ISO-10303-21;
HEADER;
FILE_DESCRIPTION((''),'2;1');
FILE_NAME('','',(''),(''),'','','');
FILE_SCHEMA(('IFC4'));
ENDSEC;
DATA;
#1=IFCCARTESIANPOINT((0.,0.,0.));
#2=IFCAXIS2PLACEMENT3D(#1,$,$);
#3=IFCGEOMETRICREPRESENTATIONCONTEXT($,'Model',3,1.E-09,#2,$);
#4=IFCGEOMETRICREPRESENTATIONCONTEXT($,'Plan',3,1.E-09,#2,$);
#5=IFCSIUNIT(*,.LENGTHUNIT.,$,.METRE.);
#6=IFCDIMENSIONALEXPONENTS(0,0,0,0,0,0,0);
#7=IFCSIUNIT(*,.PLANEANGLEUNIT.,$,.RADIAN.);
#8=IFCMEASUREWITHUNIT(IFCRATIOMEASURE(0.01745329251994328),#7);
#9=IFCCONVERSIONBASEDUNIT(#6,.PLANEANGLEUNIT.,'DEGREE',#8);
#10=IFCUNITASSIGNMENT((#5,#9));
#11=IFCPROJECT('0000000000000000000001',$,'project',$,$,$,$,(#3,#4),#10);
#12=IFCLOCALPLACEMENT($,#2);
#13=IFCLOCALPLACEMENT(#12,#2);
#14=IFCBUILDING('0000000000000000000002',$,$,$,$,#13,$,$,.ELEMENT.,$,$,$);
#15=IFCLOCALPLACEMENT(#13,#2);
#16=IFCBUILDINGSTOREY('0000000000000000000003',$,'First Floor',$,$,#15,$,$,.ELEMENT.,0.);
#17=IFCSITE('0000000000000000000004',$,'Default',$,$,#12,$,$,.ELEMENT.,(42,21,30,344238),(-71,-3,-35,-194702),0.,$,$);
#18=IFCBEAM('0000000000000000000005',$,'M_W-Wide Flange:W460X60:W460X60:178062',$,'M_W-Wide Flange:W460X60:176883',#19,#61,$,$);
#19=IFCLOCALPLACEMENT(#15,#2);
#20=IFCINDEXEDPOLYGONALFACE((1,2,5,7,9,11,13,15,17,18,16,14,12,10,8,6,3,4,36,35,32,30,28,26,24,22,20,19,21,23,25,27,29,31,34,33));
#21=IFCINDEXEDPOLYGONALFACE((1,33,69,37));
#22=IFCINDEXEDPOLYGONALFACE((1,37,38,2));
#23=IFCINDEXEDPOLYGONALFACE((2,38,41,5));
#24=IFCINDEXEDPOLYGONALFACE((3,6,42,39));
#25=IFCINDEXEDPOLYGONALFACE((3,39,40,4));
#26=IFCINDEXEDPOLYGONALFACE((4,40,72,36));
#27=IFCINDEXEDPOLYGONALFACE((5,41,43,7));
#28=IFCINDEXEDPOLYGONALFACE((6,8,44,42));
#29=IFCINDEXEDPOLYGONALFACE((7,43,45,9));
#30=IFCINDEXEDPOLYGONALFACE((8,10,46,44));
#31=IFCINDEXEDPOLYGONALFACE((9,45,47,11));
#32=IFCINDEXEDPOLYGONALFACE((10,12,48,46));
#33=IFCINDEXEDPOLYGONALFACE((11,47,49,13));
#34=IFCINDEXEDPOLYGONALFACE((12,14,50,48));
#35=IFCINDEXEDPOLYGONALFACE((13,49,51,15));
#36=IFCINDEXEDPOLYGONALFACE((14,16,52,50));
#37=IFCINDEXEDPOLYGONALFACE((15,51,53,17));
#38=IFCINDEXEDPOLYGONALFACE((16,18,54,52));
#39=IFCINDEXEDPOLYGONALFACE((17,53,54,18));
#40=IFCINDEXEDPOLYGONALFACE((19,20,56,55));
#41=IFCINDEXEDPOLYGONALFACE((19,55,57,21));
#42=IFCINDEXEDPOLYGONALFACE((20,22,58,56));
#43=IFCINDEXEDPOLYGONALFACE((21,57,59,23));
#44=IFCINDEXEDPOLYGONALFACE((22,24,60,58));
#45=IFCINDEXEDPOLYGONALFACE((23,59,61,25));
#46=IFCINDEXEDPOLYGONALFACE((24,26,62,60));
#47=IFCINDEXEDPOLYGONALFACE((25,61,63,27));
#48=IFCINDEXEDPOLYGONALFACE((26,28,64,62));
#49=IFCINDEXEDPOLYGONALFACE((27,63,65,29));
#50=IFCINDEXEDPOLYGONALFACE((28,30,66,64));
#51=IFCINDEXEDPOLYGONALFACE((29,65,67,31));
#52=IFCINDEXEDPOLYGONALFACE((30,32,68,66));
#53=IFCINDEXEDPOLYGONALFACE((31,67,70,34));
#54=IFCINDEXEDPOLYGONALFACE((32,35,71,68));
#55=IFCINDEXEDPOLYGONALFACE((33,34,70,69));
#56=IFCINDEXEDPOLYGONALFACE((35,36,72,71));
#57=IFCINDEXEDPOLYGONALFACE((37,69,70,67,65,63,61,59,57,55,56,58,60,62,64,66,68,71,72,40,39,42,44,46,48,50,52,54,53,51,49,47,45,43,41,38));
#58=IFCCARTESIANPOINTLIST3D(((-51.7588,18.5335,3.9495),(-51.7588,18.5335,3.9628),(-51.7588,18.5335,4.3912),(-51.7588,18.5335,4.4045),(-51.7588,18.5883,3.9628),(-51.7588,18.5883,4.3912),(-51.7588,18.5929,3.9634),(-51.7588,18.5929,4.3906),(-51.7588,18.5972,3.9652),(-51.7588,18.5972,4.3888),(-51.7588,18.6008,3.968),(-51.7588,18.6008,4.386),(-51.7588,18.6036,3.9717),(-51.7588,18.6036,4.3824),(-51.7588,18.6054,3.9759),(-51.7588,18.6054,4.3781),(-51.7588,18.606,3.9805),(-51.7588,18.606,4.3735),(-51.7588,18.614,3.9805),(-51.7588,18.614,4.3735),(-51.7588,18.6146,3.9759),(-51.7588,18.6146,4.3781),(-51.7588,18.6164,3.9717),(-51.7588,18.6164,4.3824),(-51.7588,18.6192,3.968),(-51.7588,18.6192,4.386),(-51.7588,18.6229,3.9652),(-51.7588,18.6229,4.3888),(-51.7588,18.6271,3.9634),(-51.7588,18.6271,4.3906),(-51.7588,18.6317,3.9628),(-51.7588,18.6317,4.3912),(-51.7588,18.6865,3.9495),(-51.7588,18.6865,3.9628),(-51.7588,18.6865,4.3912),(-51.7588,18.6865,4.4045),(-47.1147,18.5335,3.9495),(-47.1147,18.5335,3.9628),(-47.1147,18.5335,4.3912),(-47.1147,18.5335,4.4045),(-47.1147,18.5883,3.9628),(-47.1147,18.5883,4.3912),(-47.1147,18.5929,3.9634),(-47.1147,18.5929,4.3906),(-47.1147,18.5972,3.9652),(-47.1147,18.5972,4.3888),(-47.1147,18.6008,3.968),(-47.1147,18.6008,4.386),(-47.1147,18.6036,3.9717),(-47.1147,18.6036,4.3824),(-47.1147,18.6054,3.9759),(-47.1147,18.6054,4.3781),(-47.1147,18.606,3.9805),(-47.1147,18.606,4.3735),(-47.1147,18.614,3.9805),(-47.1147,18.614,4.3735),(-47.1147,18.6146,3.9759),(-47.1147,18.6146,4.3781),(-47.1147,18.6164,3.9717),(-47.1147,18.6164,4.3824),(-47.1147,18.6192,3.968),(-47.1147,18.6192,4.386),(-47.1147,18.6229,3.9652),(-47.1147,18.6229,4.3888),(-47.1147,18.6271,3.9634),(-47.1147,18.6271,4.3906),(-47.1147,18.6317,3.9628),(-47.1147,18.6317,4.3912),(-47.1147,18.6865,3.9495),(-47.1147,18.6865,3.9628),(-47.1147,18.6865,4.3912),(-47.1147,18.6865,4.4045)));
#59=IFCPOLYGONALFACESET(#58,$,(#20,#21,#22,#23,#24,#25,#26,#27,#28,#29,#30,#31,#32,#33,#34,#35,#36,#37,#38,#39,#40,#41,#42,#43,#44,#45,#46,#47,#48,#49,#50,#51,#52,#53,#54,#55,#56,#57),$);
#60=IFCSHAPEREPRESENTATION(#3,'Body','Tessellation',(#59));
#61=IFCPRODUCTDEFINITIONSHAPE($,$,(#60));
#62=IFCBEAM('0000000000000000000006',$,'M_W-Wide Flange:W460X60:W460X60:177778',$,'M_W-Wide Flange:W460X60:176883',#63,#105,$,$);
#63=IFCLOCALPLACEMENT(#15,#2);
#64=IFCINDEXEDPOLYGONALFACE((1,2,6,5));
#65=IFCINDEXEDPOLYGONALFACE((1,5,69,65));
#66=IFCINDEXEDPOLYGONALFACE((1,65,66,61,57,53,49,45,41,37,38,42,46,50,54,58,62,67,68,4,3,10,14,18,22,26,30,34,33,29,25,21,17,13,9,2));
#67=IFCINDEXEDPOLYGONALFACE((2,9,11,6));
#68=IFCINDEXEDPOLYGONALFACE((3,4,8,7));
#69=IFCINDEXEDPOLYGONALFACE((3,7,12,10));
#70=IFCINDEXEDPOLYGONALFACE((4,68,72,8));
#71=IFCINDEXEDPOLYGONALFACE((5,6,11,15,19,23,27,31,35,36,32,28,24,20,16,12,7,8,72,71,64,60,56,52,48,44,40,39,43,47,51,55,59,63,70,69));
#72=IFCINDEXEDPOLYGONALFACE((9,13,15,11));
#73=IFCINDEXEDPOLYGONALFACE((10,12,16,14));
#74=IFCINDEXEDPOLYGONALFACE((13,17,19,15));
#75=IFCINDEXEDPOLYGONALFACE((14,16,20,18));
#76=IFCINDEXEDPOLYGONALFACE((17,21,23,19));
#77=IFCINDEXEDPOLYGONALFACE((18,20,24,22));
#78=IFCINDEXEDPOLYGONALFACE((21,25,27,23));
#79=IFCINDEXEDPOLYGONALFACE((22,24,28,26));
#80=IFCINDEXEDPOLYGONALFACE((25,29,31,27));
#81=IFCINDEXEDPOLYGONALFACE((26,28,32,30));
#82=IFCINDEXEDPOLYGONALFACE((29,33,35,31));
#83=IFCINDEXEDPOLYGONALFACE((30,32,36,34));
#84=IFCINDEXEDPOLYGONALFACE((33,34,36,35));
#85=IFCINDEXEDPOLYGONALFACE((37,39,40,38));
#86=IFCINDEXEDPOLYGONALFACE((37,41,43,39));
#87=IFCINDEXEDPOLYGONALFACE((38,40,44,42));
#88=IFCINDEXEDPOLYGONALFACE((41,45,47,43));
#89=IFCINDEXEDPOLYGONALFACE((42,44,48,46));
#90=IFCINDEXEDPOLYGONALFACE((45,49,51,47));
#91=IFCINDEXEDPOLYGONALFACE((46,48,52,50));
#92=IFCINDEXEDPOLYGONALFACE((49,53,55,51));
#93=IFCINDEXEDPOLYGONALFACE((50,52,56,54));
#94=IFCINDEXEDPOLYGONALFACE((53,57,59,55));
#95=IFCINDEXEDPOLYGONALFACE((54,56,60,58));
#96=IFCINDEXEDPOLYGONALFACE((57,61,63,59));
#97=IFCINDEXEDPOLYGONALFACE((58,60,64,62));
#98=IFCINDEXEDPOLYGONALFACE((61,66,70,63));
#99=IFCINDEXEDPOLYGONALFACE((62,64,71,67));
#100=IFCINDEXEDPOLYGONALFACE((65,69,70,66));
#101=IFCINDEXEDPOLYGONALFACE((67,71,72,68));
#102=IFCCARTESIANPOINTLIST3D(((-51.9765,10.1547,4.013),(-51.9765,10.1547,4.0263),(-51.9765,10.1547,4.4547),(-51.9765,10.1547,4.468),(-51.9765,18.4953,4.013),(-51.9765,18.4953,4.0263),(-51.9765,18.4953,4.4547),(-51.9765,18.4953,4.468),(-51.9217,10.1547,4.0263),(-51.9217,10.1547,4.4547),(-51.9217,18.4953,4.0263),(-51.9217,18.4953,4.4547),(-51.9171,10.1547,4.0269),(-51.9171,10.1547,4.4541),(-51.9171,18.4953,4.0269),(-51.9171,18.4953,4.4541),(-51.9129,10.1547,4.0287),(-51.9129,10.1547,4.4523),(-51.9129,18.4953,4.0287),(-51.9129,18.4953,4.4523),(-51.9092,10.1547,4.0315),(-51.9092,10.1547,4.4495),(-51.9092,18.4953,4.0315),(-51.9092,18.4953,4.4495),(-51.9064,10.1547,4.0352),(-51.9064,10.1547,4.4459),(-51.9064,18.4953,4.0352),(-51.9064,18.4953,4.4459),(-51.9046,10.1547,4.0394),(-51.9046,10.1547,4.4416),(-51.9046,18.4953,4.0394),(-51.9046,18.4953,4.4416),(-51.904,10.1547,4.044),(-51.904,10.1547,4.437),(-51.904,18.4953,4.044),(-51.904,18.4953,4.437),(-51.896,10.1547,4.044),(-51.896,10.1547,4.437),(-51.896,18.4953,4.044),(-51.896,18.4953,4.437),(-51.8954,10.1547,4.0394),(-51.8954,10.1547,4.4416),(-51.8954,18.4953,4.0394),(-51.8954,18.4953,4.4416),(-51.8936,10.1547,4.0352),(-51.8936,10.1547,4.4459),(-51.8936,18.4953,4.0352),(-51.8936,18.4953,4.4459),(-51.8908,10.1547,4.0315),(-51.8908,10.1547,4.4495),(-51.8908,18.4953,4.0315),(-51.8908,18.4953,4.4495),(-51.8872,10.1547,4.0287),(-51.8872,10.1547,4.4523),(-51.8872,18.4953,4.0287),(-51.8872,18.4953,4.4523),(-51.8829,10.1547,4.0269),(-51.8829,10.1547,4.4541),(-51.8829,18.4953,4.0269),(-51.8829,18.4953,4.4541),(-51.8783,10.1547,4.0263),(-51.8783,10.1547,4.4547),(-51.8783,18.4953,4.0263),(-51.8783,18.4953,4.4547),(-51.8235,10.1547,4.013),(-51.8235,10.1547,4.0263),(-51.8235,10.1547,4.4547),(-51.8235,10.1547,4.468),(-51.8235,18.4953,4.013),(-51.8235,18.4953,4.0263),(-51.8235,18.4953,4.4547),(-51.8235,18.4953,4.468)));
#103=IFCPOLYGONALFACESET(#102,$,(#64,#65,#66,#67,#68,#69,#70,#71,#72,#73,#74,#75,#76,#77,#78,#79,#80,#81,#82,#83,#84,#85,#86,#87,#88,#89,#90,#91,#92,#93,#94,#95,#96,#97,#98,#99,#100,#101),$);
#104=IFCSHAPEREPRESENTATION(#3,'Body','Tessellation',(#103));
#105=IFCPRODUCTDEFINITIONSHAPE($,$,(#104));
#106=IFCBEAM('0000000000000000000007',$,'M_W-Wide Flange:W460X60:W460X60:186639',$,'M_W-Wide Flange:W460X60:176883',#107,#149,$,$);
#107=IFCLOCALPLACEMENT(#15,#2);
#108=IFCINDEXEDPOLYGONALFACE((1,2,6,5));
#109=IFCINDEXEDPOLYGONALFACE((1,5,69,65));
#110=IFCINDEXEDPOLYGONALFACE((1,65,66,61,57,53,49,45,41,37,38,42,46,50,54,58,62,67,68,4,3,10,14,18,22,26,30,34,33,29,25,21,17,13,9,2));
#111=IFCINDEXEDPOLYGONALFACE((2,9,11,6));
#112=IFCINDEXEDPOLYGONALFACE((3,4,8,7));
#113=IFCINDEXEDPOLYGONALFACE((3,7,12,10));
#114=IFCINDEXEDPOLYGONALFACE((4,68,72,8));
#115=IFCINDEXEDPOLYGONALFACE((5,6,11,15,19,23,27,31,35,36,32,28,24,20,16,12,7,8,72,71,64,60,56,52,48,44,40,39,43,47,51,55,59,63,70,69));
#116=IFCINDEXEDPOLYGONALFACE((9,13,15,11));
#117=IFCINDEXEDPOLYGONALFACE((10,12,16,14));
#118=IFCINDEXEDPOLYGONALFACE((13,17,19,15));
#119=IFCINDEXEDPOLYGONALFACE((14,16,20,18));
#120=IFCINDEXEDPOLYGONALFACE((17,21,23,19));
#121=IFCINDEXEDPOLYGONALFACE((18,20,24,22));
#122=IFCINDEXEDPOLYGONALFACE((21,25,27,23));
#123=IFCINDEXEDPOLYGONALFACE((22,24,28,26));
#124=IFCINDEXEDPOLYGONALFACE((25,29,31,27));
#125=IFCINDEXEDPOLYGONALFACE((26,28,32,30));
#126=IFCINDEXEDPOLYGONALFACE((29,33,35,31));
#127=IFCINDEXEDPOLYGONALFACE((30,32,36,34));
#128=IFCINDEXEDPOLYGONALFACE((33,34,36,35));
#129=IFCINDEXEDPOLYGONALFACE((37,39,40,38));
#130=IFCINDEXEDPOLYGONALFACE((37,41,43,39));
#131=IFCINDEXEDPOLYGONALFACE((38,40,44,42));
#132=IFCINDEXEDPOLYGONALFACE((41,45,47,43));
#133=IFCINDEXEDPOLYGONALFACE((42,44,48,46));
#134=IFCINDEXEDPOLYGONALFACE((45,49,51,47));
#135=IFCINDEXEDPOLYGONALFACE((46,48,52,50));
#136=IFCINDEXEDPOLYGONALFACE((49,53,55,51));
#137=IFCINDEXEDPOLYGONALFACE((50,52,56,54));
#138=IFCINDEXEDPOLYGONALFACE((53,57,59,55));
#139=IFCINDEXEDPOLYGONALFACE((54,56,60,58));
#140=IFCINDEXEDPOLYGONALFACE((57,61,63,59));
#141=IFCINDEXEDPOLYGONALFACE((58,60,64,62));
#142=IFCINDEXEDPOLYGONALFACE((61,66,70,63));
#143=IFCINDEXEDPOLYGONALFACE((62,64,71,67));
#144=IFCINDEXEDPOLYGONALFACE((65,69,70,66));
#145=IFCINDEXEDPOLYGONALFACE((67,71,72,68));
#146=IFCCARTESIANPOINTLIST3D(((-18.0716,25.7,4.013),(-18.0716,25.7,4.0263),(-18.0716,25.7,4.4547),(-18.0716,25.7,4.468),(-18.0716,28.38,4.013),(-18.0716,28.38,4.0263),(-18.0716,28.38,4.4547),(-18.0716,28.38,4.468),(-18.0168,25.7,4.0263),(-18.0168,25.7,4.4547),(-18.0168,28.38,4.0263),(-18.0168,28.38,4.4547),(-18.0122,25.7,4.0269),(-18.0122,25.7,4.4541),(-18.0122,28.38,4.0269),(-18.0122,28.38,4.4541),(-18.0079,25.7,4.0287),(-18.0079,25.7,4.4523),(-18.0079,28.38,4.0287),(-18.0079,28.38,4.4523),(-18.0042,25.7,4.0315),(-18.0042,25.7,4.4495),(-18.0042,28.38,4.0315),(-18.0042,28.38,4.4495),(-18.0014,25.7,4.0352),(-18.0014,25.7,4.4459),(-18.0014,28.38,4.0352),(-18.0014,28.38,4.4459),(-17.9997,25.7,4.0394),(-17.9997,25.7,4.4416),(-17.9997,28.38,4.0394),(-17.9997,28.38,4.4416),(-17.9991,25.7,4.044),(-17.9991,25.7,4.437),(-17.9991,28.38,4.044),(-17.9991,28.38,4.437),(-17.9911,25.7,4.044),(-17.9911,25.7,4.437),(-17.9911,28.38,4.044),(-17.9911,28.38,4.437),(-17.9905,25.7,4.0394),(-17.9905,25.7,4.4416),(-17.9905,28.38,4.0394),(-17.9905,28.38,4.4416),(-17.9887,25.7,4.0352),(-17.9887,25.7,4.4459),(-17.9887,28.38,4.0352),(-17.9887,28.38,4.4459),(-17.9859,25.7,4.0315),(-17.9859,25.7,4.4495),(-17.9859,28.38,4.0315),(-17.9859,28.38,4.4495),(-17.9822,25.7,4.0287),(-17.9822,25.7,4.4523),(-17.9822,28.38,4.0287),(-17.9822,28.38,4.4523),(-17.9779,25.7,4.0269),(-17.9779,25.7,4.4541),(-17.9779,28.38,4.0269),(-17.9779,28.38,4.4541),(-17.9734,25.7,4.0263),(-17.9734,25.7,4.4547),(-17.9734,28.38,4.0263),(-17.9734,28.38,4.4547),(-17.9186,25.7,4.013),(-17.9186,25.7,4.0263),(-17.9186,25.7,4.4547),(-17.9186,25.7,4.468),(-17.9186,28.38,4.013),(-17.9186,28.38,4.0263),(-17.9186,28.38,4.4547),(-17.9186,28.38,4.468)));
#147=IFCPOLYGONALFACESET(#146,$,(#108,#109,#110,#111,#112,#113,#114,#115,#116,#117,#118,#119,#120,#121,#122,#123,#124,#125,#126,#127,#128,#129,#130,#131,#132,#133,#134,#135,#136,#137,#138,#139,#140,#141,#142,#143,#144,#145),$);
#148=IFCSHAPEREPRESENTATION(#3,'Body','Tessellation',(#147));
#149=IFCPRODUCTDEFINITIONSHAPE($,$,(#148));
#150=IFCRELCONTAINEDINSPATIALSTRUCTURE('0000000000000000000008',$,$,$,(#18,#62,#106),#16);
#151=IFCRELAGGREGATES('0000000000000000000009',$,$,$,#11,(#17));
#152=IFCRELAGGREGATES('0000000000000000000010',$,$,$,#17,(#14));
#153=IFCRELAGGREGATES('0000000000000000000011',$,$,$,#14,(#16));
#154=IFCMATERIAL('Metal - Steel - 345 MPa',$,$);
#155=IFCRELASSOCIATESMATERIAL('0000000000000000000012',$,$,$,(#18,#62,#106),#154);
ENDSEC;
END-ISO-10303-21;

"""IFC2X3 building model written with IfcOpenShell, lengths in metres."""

from ifc_helpers import new_model, entity, si_unit, converted_unit, frame, frame_2d, origin, place, context, project, spatial, polyline, circle_curve, parameter, trimmed, segment, composite_curve, outline, extrude, material, element, save


model = new_model("IFC2X3")

# Units and contexts
model_context = context("Model", 3, precision=1e-09, world=origin())
plan_context = context("Plan", 3, precision=1e-09, world=origin())
ifc_project = project(units=[si_unit("LENGTHUNIT", "METRE"), converted_unit("PLANEANGLEUNIT", "DEGREE", entity("IfcRatioMeasure", 0.01745329251994328), si_unit("PLANEANGLEUNIT", "RADIAN"), dimensions=[0, 0, 0, 0, 0, 0, 0])], contexts=[model_context, plan_context])

# Site, building, storey
site_placement = place(None, origin())
site = spatial("IfcSite", under=ifc_project, at=site_placement, Name="Default", CompositionType="ELEMENT", RefLatitude=(42, 21, 30, 344238), RefLongitude=(-71, -3, -35, -194702), RefElevation=0.0)
building_placement = place(site_placement, origin())
building = spatial("IfcBuilding", under=site, at=building_placement, CompositionType="ELEMENT")
storey_placement = place(building_placement, origin())
storey = spatial("IfcBuildingStorey", under=building, at=storey_placement, Name="First Floor", CompositionType="ELEMENT", Elevation=0.0)

# Beams
ifc_material_1 = material(Name="Metal - Steel - 345 MPa")
beam_1_placement = place(storey_placement, frame((-51.9028, 18.61, 4.4045), z_axis=(0.0, 0.0, 1.0), x_axis=(0.0, -1.0, 0.0)))
element("IfcBeam", 1, at=beam_1_placement, inside=storey, material=ifc_material_1, Name="M_W-Wide Flange:W460X60:W460X60:178062", ObjectType="M_W-Wide Flange:W460X60:176883", context=model_context, shape_type="SweptSolid", body=[
    extrude(outline(composite_curve([segment(polyline([(-0.0765, -0.2142), (-0.0765, -0.2275)]), True, "CONTINUOUS"), segment(polyline([(-0.0765, -0.2275), (0.0765, -0.2275)]), True, "CONTINUOUS"), segment(polyline([(0.0765, -0.2275), (0.0765, -0.2142)]), True, "CONTINUOUS"), segment(polyline([(0.0765, -0.2142), (0.0217, -0.2142)]), True, "CONTINUOUS"), segment(trimmed(circle_curve(frame_2d((0.0217, -0.1965), x_axis=(1.0, 0.0)), 0.0177), [parameter(180.0)], [parameter(270.0)], True, "PARAMETER"), False, "CONTINUOUS"), segment(polyline([(0.004, -0.1965), (0.004, 0.1965)]), True, "CONTINUOUS"), segment(trimmed(circle_curve(frame_2d((0.0217, 0.1965), x_axis=(1.0, 0.0)), 0.0177), [parameter(90.0)], [parameter(180.0)], True, "PARAMETER"), False, "CONTINUOUS"), segment(polyline([(0.0217, 0.2142), (0.0765, 0.2142)]), True, "CONTINUOUS"), segment(polyline([(0.0765, 0.2142), (0.0765, 0.2275)]), True, "CONTINUOUS"), segment(polyline([(0.0765, 0.2275), (-0.0765, 0.2275)]), True, "CONTINUOUS"), segment(polyline([(-0.0765, 0.2275), (-0.0765, 0.2142)]), True, "CONTINUOUS"), segment(polyline([(-0.0765, 0.2142), (-0.0217, 0.2142)]), True, "CONTINUOUS"), segment(trimmed(circle_curve(frame_2d((-0.0217, 0.1965), x_axis=(1.0, 0.0)), 0.0177), [parameter(360.0)], [parameter(90.0)], True, "PARAMETER"), False, "CONTINUOUS"), segment(polyline([(-0.004, 0.1965), (-0.004, -0.1965)]), True, "CONTINUOUS"), segment(trimmed(circle_curve(frame_2d((-0.0217, -0.1965), x_axis=(1.0, 0.0)), 0.0177), [parameter(270.0)], [parameter(0.0)], True, "PARAMETER"), False, "CONTINUOUS"), segment(polyline([(-0.0217, -0.2142), (-0.0765, -0.2142)]), True, "CONTINUOUS")], self_intersect=False)), frame((0.0, 0.144, -0.2275), z_axis=(0.0, -1.0, 0.0), x_axis=(1.0, 0.0, 0.0)), (0.0, 0.0, -1.0), 4.6441),
])
beam_2_placement = place(storey_placement, frame((-51.9, 18.6116, 4.468), z_axis=(0.0, 0.0, 1.0), x_axis=(-1.0, 0.0, 0.0)))
element("IfcBeam", 2, at=beam_2_placement, inside=storey, material=ifc_material_1, Name="M_W-Wide Flange:W460X60:W460X60:177778", ObjectType="M_W-Wide Flange:W460X60:176883", context=model_context, shape_type="SweptSolid", body=[
    extrude(outline(composite_curve([segment(polyline([(0.2142, -0.0765), (0.2275, -0.0765)]), True, "CONTINUOUS"), segment(polyline([(0.2275, -0.0765), (0.2275, 0.0765)]), True, "CONTINUOUS"), segment(polyline([(0.2275, 0.0765), (0.2142, 0.0765)]), True, "CONTINUOUS"), segment(polyline([(0.2142, 0.0765), (0.2142, 0.0217)]), True, "CONTINUOUS"), segment(trimmed(circle_curve(frame_2d((0.1965, 0.0217), x_axis=(1.0, 0.0)), 0.0177), [parameter(270.0)], [parameter(360.0)], True, "PARAMETER"), False, "CONTINUOUS"), segment(polyline([(0.1965, 0.004), (-0.1965, 0.004)]), True, "CONTINUOUS"), segment(trimmed(circle_curve(frame_2d((-0.1965, 0.0217), x_axis=(0.0, -1.0)), 0.0177), [parameter(270.0)], [parameter(360.0)], True, "PARAMETER"), False, "CONTINUOUS"), segment(polyline([(-0.2142, 0.0217), (-0.2142, 0.0765)]), True, "CONTINUOUS"), segment(polyline([(-0.2142, 0.0765), (-0.2275, 0.0765)]), True, "CONTINUOUS"), segment(polyline([(-0.2275, 0.0765), (-0.2275, -0.0765)]), True, "CONTINUOUS"), segment(polyline([(-0.2275, -0.0765), (-0.2142, -0.0765)]), True, "CONTINUOUS"), segment(polyline([(-0.2142, -0.0765), (-0.2142, -0.0217)]), True, "CONTINUOUS"), segment(trimmed(circle_curve(frame_2d((-0.1965, -0.0217), x_axis=(-1.0, 0.0)), 0.0177), [parameter(270.0)], [parameter(360.0)], True, "PARAMETER"), False, "CONTINUOUS"), segment(polyline([(-0.1965, -0.004), (0.1965, -0.004)]), True, "CONTINUOUS"), segment(trimmed(circle_curve(frame_2d((0.1965, -0.0217), x_axis=(0.0, 1.0)), 0.0177), [parameter(270.0)], [parameter(0.0)], True, "PARAMETER"), False, "CONTINUOUS"), segment(polyline([(0.2142, -0.0217), (0.2142, -0.0765)]), True, "CONTINUOUS")], self_intersect=False)), frame((0.0, 8.4569, -0.2275), z_axis=(0.0, -1.0, 0.0), x_axis=(0.0, 0.0, -1.0)), (0.0, 0.0, 1.0), 8.3406),
])
beam_3_placement = place(storey_placement, frame((-17.9951, 25.4311, 4.468)))
element("IfcBeam", 3, at=beam_3_placement, inside=storey, material=ifc_material_1, Name="M_W-Wide Flange:W460X60:W460X60:186639", ObjectType="M_W-Wide Flange:W460X60:176883", context=model_context, shape_type="SweptSolid", body=[
    extrude(outline(composite_curve([segment(polyline([(-0.0765, -0.2142), (-0.0765, -0.2275)]), True, "CONTINUOUS"), segment(polyline([(-0.0765, -0.2275), (0.0765, -0.2275)]), True, "CONTINUOUS"), segment(polyline([(0.0765, -0.2275), (0.0765, -0.2142)]), True, "CONTINUOUS"), segment(polyline([(0.0765, -0.2142), (0.0217, -0.2142)]), True, "CONTINUOUS"), segment(trimmed(circle_curve(frame_2d((0.0217, -0.1965), x_axis=(1.0, 0.0)), 0.0177), [parameter(180.0)], [parameter(270.0)], True, "PARAMETER"), False, "CONTINUOUS"), segment(polyline([(0.004, -0.1965), (0.004, 0.1965)]), True, "CONTINUOUS"), segment(trimmed(circle_curve(frame_2d((0.0217, 0.1965), x_axis=(1.0, 0.0)), 0.0177), [parameter(90.0)], [parameter(180.0)], True, "PARAMETER"), False, "CONTINUOUS"), segment(polyline([(0.0217, 0.2142), (0.0765, 0.2142)]), True, "CONTINUOUS"), segment(polyline([(0.0765, 0.2142), (0.0765, 0.2275)]), True, "CONTINUOUS"), segment(polyline([(0.0765, 0.2275), (-0.0765, 0.2275)]), True, "CONTINUOUS"), segment(polyline([(-0.0765, 0.2275), (-0.0765, 0.2142)]), True, "CONTINUOUS"), segment(polyline([(-0.0765, 0.2142), (-0.0217, 0.2142)]), True, "CONTINUOUS"), segment(trimmed(circle_curve(frame_2d((-0.0217, 0.1965), x_axis=(1.0, 0.0)), 0.0177), [parameter(360.0)], [parameter(90.0)], True, "PARAMETER"), False, "CONTINUOUS"), segment(polyline([(-0.004, 0.1965), (-0.004, -0.1965)]), True, "CONTINUOUS"), segment(trimmed(circle_curve(frame_2d((-0.0217, -0.1965), x_axis=(1.0, 0.0)), 0.0177), [parameter(270.0)], [parameter(0.0)], True, "PARAMETER"), False, "CONTINUOUS"), segment(polyline([(-0.0217, -0.2142), (-0.0765, -0.2142)]), True, "CONTINUOUS")], self_intersect=False)), frame((0.0, 0.2689, -0.2275), z_axis=(0.0, -1.0, 0.0), x_axis=(1.0, 0.0, 0.0)), (0.0, 0.0, -1.0), 2.68),
])

save(model, "model.ifc")
